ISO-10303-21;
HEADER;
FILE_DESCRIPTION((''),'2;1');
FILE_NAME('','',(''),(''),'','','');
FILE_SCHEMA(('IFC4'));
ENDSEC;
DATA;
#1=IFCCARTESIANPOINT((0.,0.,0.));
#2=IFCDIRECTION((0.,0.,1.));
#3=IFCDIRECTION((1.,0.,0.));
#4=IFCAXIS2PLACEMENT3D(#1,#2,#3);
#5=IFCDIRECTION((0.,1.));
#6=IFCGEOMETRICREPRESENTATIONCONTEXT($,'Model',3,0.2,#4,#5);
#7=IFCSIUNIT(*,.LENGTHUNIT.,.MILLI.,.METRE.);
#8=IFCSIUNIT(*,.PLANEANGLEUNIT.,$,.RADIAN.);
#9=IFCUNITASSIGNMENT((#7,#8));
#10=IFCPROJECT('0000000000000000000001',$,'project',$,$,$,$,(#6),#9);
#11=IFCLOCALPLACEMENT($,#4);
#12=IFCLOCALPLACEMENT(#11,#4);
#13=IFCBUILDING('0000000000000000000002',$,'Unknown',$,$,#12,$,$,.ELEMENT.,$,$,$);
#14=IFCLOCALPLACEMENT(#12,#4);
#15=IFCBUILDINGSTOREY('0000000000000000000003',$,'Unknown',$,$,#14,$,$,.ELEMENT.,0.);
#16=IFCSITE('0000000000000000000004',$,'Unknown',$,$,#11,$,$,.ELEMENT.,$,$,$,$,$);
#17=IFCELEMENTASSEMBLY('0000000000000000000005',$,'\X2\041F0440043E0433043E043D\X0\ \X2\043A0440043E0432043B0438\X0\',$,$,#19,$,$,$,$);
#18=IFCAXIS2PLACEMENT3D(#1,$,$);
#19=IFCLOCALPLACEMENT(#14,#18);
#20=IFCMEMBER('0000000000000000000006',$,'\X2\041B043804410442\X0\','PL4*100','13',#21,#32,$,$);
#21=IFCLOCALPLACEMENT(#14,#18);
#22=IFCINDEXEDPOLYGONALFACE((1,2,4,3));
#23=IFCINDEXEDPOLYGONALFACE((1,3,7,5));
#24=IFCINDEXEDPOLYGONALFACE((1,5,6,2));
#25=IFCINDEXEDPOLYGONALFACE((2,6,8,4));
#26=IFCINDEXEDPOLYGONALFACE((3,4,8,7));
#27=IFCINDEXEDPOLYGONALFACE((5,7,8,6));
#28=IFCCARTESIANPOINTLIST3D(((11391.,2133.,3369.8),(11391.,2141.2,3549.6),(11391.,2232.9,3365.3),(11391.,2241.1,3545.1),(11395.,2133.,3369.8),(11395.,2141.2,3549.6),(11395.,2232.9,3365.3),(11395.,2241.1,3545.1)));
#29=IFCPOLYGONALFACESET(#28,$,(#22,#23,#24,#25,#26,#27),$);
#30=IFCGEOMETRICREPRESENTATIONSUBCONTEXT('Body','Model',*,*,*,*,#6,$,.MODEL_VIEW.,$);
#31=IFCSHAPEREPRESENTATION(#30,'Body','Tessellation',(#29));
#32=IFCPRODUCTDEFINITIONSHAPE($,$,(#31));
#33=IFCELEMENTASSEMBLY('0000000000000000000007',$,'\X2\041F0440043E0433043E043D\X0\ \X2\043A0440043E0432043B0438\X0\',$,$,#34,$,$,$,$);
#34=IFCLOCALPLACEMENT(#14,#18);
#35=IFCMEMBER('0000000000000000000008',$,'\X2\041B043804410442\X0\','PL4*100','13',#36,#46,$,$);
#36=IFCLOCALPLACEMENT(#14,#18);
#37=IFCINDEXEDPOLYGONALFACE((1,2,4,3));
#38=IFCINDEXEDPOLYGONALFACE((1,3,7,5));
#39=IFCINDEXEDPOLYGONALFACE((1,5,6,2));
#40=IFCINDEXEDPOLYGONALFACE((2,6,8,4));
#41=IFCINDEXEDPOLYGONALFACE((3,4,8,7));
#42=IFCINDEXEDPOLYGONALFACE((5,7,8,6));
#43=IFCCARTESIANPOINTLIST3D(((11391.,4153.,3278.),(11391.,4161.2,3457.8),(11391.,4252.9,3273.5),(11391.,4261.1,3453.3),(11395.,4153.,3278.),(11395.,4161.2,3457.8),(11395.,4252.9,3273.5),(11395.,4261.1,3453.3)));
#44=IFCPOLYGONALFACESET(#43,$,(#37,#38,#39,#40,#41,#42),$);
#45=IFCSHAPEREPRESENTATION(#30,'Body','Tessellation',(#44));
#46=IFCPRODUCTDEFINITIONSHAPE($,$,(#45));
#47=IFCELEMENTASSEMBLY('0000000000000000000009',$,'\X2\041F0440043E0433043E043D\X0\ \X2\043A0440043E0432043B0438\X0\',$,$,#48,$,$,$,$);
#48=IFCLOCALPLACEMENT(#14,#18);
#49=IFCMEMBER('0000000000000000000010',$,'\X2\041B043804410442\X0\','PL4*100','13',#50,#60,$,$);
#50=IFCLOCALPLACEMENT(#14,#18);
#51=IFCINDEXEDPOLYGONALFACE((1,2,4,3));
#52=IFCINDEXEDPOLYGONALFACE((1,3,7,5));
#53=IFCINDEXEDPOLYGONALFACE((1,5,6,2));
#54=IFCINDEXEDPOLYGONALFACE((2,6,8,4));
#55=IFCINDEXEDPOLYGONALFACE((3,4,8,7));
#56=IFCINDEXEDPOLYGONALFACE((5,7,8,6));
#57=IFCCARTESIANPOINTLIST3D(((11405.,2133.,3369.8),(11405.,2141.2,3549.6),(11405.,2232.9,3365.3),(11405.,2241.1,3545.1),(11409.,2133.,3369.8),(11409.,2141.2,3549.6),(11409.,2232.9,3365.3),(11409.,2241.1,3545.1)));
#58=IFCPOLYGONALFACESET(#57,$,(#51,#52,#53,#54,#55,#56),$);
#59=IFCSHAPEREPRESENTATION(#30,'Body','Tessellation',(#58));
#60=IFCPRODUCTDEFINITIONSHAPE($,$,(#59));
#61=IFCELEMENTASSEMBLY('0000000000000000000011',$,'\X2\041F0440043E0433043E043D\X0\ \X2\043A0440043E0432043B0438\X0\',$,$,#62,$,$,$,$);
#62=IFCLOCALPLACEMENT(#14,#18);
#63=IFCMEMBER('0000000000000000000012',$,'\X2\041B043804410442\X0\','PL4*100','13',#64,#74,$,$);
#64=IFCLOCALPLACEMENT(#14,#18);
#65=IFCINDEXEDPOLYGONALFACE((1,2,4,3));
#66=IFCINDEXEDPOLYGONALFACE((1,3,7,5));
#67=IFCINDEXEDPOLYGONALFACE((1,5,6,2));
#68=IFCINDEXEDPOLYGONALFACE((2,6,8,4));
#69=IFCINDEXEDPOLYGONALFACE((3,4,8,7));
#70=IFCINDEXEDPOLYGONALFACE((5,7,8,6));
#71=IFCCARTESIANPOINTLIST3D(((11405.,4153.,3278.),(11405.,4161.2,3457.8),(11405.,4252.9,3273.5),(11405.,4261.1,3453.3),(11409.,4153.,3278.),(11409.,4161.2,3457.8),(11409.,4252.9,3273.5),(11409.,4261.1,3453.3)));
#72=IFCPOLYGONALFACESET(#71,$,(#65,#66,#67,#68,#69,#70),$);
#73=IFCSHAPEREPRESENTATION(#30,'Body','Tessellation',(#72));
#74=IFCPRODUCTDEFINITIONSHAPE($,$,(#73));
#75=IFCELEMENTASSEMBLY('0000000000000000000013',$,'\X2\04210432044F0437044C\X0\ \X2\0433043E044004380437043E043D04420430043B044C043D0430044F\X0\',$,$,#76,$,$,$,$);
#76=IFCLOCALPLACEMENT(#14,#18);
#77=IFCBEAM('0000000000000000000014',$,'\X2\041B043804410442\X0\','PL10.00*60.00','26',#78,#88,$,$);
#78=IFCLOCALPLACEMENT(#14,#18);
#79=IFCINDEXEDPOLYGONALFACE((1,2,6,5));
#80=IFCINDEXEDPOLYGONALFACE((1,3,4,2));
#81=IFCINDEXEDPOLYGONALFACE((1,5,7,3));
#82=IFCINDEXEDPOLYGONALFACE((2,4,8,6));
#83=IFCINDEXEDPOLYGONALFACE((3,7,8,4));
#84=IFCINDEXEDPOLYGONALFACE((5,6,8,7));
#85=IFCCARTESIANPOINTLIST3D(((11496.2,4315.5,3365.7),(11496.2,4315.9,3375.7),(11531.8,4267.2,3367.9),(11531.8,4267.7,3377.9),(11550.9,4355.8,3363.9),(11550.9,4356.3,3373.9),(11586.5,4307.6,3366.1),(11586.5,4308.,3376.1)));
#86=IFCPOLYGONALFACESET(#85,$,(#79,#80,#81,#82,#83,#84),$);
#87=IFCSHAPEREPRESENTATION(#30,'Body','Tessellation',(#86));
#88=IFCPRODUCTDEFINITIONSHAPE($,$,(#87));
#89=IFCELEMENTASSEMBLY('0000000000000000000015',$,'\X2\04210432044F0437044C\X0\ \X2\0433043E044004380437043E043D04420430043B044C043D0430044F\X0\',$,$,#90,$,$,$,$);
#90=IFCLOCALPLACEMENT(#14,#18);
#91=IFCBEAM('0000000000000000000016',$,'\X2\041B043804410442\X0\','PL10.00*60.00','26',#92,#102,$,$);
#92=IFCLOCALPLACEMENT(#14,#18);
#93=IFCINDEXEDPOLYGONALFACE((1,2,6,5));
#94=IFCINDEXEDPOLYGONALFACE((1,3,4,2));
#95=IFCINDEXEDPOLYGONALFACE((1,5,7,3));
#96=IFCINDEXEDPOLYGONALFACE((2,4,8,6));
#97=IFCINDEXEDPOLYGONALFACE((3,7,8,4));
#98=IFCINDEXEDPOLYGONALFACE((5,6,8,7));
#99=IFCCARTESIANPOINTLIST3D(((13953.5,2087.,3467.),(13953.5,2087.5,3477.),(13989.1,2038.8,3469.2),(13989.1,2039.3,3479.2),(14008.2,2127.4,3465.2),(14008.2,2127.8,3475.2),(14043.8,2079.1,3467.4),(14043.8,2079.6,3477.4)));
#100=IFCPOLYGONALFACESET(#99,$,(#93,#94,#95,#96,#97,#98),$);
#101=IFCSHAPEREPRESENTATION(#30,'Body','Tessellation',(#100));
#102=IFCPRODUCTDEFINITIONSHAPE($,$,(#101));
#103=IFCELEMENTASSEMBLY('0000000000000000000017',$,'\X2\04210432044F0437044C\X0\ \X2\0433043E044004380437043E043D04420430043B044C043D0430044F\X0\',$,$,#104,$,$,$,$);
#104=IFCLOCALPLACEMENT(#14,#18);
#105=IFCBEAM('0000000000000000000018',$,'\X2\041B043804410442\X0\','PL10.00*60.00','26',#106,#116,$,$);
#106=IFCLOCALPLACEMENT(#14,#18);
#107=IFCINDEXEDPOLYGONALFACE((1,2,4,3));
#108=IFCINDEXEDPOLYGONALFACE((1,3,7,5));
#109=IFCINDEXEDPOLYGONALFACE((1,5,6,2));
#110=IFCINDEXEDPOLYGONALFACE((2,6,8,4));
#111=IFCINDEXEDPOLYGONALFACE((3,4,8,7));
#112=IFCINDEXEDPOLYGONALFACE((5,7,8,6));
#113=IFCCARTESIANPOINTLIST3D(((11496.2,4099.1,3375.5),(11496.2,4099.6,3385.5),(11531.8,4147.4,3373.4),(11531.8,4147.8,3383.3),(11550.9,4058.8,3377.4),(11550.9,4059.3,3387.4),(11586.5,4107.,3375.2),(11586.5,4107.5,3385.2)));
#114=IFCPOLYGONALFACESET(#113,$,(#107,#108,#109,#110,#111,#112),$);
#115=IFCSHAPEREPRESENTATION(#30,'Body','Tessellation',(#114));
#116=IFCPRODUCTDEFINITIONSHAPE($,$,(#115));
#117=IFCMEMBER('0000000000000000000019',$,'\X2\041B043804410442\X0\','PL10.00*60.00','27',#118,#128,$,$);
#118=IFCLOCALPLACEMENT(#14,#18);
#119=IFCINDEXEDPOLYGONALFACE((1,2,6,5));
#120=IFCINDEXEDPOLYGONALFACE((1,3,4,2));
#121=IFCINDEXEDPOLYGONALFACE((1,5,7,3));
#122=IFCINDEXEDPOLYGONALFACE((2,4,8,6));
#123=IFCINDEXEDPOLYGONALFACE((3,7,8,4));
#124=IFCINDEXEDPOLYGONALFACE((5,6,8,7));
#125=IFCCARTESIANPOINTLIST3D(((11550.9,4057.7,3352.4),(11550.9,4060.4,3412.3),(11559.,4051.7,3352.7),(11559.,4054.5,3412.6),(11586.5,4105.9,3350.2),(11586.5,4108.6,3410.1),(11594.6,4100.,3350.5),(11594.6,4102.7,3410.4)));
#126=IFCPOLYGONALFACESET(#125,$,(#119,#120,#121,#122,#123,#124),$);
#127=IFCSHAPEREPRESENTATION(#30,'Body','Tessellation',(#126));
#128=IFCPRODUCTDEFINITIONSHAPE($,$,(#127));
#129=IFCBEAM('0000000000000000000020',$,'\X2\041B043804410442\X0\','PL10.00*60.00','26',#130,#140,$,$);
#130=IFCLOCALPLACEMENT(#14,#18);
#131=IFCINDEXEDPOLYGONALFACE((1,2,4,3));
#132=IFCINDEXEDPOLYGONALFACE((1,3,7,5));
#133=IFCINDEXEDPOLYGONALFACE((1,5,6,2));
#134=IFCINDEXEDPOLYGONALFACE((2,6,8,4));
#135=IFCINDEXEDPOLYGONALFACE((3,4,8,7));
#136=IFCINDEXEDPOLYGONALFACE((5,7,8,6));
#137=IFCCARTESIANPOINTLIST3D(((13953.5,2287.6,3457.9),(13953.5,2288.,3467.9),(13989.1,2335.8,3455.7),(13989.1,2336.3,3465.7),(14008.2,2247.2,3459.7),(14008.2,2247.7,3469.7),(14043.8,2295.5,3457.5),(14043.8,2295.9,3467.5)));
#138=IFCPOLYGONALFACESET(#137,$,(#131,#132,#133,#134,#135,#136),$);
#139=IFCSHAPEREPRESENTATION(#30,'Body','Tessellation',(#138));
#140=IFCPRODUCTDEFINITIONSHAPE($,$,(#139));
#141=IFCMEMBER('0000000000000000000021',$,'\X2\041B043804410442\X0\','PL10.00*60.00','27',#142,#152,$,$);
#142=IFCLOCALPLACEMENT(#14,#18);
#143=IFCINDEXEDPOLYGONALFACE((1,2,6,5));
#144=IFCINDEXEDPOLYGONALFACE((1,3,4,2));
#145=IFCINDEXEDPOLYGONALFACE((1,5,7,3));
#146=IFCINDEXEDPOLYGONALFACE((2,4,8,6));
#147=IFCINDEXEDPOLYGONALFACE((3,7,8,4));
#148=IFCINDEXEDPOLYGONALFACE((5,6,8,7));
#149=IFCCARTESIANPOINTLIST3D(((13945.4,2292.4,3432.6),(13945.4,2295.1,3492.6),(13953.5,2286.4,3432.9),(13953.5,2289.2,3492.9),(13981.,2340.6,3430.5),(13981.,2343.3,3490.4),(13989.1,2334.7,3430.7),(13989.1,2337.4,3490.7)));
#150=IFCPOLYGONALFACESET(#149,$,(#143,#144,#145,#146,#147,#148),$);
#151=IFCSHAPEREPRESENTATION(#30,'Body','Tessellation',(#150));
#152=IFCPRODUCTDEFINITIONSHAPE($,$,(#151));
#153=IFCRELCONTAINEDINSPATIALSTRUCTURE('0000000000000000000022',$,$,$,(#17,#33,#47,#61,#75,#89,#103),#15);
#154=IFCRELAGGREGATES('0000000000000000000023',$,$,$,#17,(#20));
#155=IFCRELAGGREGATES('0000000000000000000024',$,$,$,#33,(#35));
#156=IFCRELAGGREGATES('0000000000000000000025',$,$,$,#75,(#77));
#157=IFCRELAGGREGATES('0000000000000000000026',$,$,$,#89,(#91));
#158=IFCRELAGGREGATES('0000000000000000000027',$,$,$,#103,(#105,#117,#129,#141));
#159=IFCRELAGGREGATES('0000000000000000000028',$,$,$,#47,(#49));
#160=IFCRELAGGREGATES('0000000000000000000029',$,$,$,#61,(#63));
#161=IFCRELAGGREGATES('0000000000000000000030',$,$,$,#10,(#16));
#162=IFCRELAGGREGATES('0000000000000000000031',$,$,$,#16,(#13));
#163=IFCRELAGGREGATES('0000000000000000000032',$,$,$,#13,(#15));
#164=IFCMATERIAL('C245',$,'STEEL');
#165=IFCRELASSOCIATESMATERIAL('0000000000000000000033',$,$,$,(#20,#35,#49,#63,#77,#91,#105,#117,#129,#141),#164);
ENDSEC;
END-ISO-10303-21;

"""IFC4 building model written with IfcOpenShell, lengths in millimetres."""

from ifc_helpers import new_model, si_unit, direction, frame, origin_with_axes, place, context, subcontext, project, spatial, line, indexed_curve, outline, extrude, material, element, aggregate, save


model = new_model("IFC4")

# Units and contexts
model_context = context("Model", 3, precision=0.2, world=origin_with_axes(), true_north=direction((0.0, 1.0)))
body_context = subcontext(model_context, "Body", "Model", "MODEL_VIEW")
ifc_project = project(units=[si_unit("LENGTHUNIT", "METRE", prefix="MILLI"), si_unit("PLANEANGLEUNIT", "RADIAN")], contexts=[model_context])

# Site, building, storey
site_placement = place(None, origin_with_axes())
site = spatial("IfcSite", under=ifc_project, at=site_placement, Name="Unknown", CompositionType="ELEMENT")
building_placement = place(site_placement, origin_with_axes())
building = spatial("IfcBuilding", under=site, at=building_placement, Name="Unknown", CompositionType="ELEMENT")
storey_placement = place(building_placement, origin_with_axes())
storey = spatial("IfcBuildingStorey", under=building, at=storey_placement, Name="Unknown", CompositionType="ELEMENT", Elevation=0.0)

# Element assembly, member
assembly_1_placement = place(storey_placement, frame((5405.0, 2187.1, 3457.5), z_axis=(0.0, -0.998969, 0.045408), x_axis=(1.0, 0.0, 0.0)))
assembly_1 = element("IfcElementAssembly", 1, at=assembly_1_placement, inside=storey, Name="Прогон кровли")
ifc_material_1 = material(Name="C245", Category="STEEL")
member_1_placement = place(assembly_1_placement, frame((5988.0, -90.0, 0.0), z_axis=(-1.0, 0.0, 0.0), x_axis=(0.0, 1.0, 0.0)))
member_1 = element("IfcMember", 2, at=member_1_placement, material=ifc_material_1, Name="Лист", Description="PL4*100", ObjectType="13", context=body_context, shape_type="SolidModel", body=[
    extrude(outline(indexed_curve([(-2.0, -50.0), (2.0, -50.0), (2.0, 50.0), (-2.0, 50.0)], segments=[line(1, 2, 3, 4, 1)])), frame((0.0, 0.0, 0.0), z_axis=(-1.0, 0.0, 0.0), x_axis=(0.0, 0.0, 1.0)), (0.0, 0.0, -1.0), 180.0),
])
aggregate(assembly_1, [member_1])

# Element assembly, member
assembly_2_placement = place(storey_placement, frame((5405.0, 4207.1, 3365.6), z_axis=(0.0, -0.998969, 0.045408), x_axis=(1.0, 0.0, 0.0)))
assembly_2 = element("IfcElementAssembly", 3, at=assembly_2_placement, inside=storey, Name="Прогон кровли")
member_2_placement = place(assembly_2_placement, frame((5988.0, -90.0, 0.0), z_axis=(-1.0, 0.0, 0.0), x_axis=(0.0, 1.0, 0.0)))
member_2 = element("IfcMember", 4, at=member_2_placement, material=ifc_material_1, Name="Лист", Description="PL4*100", ObjectType="13", context=body_context, shape_type="SolidModel", body=[
    extrude(outline(indexed_curve([(-2.0, -50.0), (2.0, -50.0), (2.0, 50.0), (-2.0, 50.0)], segments=[line(1, 2, 3, 4, 1)])), frame((0.0, 0.0, 0.0), z_axis=(-1.0, 0.0, 0.0), x_axis=(0.0, 0.0, 1.0)), (0.0, 0.0, -1.0), 180.0),
])
aggregate(assembly_2, [member_2])

# Element assembly, member
assembly_3_placement = place(storey_placement, frame((17395.0, 2187.1, 3457.5), z_axis=(0.0, 0.998969, -0.045408), x_axis=(-1.0, 0.0, 0.0)))
assembly_3 = element("IfcElementAssembly", 5, at=assembly_3_placement, inside=storey, Name="Прогон кровли")
member_3_placement = place(assembly_3_placement, frame((5988.0, -90.0, 0.0), z_axis=(-1.0, 0.0, 0.0), x_axis=(0.0, 1.0, 0.0)))
member_3 = element("IfcMember", 6, at=member_3_placement, material=ifc_material_1, Name="Лист", Description="PL4*100", ObjectType="13", context=body_context, shape_type="SolidModel", body=[
    extrude(outline(indexed_curve([(-2.0, -50.0), (2.0, -50.0), (2.0, 50.0), (-2.0, 50.0)], segments=[line(1, 2, 3, 4, 1)])), frame((0.0, 0.0, 0.0), z_axis=(-1.0, 0.0, 0.0), x_axis=(0.0, 0.0, 1.0)), (0.0, 0.0, -1.0), 180.0),
])

# Element assembly, member
assembly_4_placement = place(storey_placement, frame((17395.0, 4207.1, 3365.6), z_axis=(0.0, 0.998969, -0.045408), x_axis=(-1.0, 0.0, 0.0)))
assembly_4 = element("IfcElementAssembly", 7, at=assembly_4_placement, inside=storey, Name="Прогон кровли")
member_4_placement = place(assembly_4_placement, frame((5988.0, -90.0, 0.0), z_axis=(-1.0, 0.0, 0.0), x_axis=(0.0, 1.0, 0.0)))
member_4 = element("IfcMember", 8, at=member_4_placement, material=ifc_material_1, Name="Лист", Description="PL4*100", ObjectType="13", context=body_context, shape_type="SolidModel", body=[
    extrude(outline(indexed_curve([(-2.0, -50.0), (2.0, -50.0), (2.0, 50.0), (-2.0, 50.0)], segments=[line(1, 2, 3, 4, 1)])), frame((0.0, 0.0, 0.0), z_axis=(-1.0, 0.0, 0.0), x_axis=(0.0, 0.0, 1.0)), (0.0, 0.0, -1.0), 180.0),
])

# Element assemblies, beams
assembly_5_placement = place(storey_placement, frame((11400.0, 4207.5, 3375.6), z_axis=(0.593795, -0.803786, 0.036536), x_axis=(0.804616, 0.593183, -0.026963)))
assembly_5 = element("IfcElementAssembly", 9, at=assembly_5_placement, inside=storey, Name="Связь горизонтальная")
beam_1_placement = place(assembly_5_placement, frame((141.7, 0.0, 0.0), z_axis=(0.0, -1.0, 0.0), x_axis=(1.0, 0.0, 0.0)))
beam_1 = element("IfcBeam", 10, at=beam_1_placement, material=ifc_material_1, Name="Лист", Description="PL10.00*60.00", ObjectType="26", context=body_context, shape_type="SolidModel", body=[
    extrude(outline(indexed_curve([(-5.0, -30.0), (5.0, -30.0), (5.0, 30.0), (-5.0, 30.0)], segments=[line(1, 2, 3, 4, 1)])), frame((0.0, 0.0, 0.0), z_axis=(-1.0, 0.0, 0.0), x_axis=(0.0, 0.0, 1.0)), (0.0, 0.0, -1.0), 68.0),
])
aggregate(assembly_5, [beam_1])
assembly_6_placement = place(storey_placement, frame((11400.0, 167.5, 3559.3), z_axis=(0.593795, -0.803786, 0.036536), x_axis=(0.804616, 0.593183, -0.026963)))
assembly_6 = element("IfcElementAssembly", 11, at=assembly_6_placement, inside=storey, Name="Связь горизонтальная")
beam_2_placement = place(assembly_6_placement, frame((3263.7, 0.0, 0.0), z_axis=(0.0, -1.0, 0.0), x_axis=(-1.0, 0.0, 0.0)))
beam_2 = element("IfcBeam", 12, at=beam_2_placement, material=ifc_material_1, Name="Лист", Description="PL10.00*60.00", ObjectType="26", context=body_context, shape_type="SolidModel", body=[
    extrude(outline(indexed_curve([(-5.0, -30.0), (5.0, -30.0), (5.0, 30.0), (-5.0, 30.0)], segments=[line(1, 2, 3, 4, 1)])), frame((0.0, 0.0, 0.0), z_axis=(-1.0, 0.0, 0.0), x_axis=(0.0, 0.0, 1.0)), (0.0, 0.0, -1.0), 68.0),
])
aggregate(assembly_6, [beam_2])

# Element assembly, beams, members
assembly_7_placement = place(storey_placement, frame((11400.0, 4207.5, 3375.6), z_axis=(-0.593795, -0.803786, 0.036536), x_axis=(0.804616, -0.593183, 0.026963)))
assembly_7 = element("IfcElementAssembly", 13, at=assembly_7_placement, inside=storey, Name="Связь горизонтальная")
beam_3_placement = place(assembly_7_placement, frame((141.7, 0.0, 0.0), z_axis=(0.0, 1.0, 0.0), x_axis=(1.0, 0.0, 0.0)))
beam_3 = element("IfcBeam", 14, at=beam_3_placement, material=ifc_material_1, Name="Лист", Description="PL10.00*60.00", ObjectType="26", context=body_context, shape_type="SolidModel", body=[
    extrude(outline(indexed_curve([(-5.0, -30.0), (5.0, -30.0), (5.0, 30.0), (-5.0, 30.0)], segments=[line(1, 2, 3, 4, 1)])), frame((0.0, 0.0, 0.0), z_axis=(-1.0, 0.0, 0.0), x_axis=(0.0, 0.0, 1.0)), (0.0, 0.0, -1.0), 68.0),
])
member_5_placement = place(assembly_7_placement, frame((214.7, 30.0, 0.0), z_axis=(-1.0, 0.0, 0.0), x_axis=(0.0, -1.0, 0.0)))
member_5 = element("IfcMember", 15, at=member_5_placement, material=ifc_material_1, Name="Лист", Description="PL10.00*60.00", ObjectType="27", context=body_context, shape_type="SolidModel", body=[
    extrude(outline(indexed_curve([(-5.0, -30.0), (5.0, -30.0), (5.0, 30.0), (-5.0, 30.0)], segments=[line(1, 2, 3, 4, 1)])), frame((0.0, 0.0, 0.0), z_axis=(-1.0, 0.0, 0.0), x_axis=(0.0, 0.0, 1.0)), (0.0, 0.0, -1.0), 60.0),
])
beam_4_placement = place(assembly_7_placement, frame((3263.7, 0.0, 0.0), z_axis=(0.0, -1.0, 0.0), x_axis=(-1.0, 0.0, 0.0)))
beam_4 = element("IfcBeam", 16, at=beam_4_placement, material=ifc_material_1, Name="Лист", Description="PL10.00*60.00", ObjectType="26", context=body_context, shape_type="SolidModel", body=[
    extrude(outline(indexed_curve([(-5.0, -30.0), (5.0, -30.0), (5.0, 30.0), (-5.0, 30.0)], segments=[line(1, 2, 3, 4, 1)])), frame((0.0, 0.0, 0.0), z_axis=(-1.0, 0.0, 0.0), x_axis=(0.0, 0.0, 1.0)), (0.0, 0.0, -1.0), 68.0),
])
member_6_placement = place(assembly_7_placement, frame((3190.7, -30.0, 0.0), z_axis=(1.0, 0.0, 0.0), x_axis=(0.0, 1.0, 0.0)))
member_6 = element("IfcMember", 17, at=member_6_placement, material=ifc_material_1, Name="Лист", Description="PL10.00*60.00", ObjectType="27", context=body_context, shape_type="SolidModel", body=[
    extrude(outline(indexed_curve([(-5.0, -30.0), (5.0, -30.0), (5.0, 30.0), (-5.0, 30.0)], segments=[line(1, 2, 3, 4, 1)])), frame((0.0, 0.0, 0.0), z_axis=(-1.0, 0.0, 0.0), x_axis=(0.0, 0.0, 1.0)), (0.0, 0.0, -1.0), 60.0),
])
aggregate(assembly_7, [beam_3, member_5, beam_4, member_6])

aggregate(assembly_3, [member_3])
aggregate(assembly_4, [member_4])

save(model, "model.ifc")
